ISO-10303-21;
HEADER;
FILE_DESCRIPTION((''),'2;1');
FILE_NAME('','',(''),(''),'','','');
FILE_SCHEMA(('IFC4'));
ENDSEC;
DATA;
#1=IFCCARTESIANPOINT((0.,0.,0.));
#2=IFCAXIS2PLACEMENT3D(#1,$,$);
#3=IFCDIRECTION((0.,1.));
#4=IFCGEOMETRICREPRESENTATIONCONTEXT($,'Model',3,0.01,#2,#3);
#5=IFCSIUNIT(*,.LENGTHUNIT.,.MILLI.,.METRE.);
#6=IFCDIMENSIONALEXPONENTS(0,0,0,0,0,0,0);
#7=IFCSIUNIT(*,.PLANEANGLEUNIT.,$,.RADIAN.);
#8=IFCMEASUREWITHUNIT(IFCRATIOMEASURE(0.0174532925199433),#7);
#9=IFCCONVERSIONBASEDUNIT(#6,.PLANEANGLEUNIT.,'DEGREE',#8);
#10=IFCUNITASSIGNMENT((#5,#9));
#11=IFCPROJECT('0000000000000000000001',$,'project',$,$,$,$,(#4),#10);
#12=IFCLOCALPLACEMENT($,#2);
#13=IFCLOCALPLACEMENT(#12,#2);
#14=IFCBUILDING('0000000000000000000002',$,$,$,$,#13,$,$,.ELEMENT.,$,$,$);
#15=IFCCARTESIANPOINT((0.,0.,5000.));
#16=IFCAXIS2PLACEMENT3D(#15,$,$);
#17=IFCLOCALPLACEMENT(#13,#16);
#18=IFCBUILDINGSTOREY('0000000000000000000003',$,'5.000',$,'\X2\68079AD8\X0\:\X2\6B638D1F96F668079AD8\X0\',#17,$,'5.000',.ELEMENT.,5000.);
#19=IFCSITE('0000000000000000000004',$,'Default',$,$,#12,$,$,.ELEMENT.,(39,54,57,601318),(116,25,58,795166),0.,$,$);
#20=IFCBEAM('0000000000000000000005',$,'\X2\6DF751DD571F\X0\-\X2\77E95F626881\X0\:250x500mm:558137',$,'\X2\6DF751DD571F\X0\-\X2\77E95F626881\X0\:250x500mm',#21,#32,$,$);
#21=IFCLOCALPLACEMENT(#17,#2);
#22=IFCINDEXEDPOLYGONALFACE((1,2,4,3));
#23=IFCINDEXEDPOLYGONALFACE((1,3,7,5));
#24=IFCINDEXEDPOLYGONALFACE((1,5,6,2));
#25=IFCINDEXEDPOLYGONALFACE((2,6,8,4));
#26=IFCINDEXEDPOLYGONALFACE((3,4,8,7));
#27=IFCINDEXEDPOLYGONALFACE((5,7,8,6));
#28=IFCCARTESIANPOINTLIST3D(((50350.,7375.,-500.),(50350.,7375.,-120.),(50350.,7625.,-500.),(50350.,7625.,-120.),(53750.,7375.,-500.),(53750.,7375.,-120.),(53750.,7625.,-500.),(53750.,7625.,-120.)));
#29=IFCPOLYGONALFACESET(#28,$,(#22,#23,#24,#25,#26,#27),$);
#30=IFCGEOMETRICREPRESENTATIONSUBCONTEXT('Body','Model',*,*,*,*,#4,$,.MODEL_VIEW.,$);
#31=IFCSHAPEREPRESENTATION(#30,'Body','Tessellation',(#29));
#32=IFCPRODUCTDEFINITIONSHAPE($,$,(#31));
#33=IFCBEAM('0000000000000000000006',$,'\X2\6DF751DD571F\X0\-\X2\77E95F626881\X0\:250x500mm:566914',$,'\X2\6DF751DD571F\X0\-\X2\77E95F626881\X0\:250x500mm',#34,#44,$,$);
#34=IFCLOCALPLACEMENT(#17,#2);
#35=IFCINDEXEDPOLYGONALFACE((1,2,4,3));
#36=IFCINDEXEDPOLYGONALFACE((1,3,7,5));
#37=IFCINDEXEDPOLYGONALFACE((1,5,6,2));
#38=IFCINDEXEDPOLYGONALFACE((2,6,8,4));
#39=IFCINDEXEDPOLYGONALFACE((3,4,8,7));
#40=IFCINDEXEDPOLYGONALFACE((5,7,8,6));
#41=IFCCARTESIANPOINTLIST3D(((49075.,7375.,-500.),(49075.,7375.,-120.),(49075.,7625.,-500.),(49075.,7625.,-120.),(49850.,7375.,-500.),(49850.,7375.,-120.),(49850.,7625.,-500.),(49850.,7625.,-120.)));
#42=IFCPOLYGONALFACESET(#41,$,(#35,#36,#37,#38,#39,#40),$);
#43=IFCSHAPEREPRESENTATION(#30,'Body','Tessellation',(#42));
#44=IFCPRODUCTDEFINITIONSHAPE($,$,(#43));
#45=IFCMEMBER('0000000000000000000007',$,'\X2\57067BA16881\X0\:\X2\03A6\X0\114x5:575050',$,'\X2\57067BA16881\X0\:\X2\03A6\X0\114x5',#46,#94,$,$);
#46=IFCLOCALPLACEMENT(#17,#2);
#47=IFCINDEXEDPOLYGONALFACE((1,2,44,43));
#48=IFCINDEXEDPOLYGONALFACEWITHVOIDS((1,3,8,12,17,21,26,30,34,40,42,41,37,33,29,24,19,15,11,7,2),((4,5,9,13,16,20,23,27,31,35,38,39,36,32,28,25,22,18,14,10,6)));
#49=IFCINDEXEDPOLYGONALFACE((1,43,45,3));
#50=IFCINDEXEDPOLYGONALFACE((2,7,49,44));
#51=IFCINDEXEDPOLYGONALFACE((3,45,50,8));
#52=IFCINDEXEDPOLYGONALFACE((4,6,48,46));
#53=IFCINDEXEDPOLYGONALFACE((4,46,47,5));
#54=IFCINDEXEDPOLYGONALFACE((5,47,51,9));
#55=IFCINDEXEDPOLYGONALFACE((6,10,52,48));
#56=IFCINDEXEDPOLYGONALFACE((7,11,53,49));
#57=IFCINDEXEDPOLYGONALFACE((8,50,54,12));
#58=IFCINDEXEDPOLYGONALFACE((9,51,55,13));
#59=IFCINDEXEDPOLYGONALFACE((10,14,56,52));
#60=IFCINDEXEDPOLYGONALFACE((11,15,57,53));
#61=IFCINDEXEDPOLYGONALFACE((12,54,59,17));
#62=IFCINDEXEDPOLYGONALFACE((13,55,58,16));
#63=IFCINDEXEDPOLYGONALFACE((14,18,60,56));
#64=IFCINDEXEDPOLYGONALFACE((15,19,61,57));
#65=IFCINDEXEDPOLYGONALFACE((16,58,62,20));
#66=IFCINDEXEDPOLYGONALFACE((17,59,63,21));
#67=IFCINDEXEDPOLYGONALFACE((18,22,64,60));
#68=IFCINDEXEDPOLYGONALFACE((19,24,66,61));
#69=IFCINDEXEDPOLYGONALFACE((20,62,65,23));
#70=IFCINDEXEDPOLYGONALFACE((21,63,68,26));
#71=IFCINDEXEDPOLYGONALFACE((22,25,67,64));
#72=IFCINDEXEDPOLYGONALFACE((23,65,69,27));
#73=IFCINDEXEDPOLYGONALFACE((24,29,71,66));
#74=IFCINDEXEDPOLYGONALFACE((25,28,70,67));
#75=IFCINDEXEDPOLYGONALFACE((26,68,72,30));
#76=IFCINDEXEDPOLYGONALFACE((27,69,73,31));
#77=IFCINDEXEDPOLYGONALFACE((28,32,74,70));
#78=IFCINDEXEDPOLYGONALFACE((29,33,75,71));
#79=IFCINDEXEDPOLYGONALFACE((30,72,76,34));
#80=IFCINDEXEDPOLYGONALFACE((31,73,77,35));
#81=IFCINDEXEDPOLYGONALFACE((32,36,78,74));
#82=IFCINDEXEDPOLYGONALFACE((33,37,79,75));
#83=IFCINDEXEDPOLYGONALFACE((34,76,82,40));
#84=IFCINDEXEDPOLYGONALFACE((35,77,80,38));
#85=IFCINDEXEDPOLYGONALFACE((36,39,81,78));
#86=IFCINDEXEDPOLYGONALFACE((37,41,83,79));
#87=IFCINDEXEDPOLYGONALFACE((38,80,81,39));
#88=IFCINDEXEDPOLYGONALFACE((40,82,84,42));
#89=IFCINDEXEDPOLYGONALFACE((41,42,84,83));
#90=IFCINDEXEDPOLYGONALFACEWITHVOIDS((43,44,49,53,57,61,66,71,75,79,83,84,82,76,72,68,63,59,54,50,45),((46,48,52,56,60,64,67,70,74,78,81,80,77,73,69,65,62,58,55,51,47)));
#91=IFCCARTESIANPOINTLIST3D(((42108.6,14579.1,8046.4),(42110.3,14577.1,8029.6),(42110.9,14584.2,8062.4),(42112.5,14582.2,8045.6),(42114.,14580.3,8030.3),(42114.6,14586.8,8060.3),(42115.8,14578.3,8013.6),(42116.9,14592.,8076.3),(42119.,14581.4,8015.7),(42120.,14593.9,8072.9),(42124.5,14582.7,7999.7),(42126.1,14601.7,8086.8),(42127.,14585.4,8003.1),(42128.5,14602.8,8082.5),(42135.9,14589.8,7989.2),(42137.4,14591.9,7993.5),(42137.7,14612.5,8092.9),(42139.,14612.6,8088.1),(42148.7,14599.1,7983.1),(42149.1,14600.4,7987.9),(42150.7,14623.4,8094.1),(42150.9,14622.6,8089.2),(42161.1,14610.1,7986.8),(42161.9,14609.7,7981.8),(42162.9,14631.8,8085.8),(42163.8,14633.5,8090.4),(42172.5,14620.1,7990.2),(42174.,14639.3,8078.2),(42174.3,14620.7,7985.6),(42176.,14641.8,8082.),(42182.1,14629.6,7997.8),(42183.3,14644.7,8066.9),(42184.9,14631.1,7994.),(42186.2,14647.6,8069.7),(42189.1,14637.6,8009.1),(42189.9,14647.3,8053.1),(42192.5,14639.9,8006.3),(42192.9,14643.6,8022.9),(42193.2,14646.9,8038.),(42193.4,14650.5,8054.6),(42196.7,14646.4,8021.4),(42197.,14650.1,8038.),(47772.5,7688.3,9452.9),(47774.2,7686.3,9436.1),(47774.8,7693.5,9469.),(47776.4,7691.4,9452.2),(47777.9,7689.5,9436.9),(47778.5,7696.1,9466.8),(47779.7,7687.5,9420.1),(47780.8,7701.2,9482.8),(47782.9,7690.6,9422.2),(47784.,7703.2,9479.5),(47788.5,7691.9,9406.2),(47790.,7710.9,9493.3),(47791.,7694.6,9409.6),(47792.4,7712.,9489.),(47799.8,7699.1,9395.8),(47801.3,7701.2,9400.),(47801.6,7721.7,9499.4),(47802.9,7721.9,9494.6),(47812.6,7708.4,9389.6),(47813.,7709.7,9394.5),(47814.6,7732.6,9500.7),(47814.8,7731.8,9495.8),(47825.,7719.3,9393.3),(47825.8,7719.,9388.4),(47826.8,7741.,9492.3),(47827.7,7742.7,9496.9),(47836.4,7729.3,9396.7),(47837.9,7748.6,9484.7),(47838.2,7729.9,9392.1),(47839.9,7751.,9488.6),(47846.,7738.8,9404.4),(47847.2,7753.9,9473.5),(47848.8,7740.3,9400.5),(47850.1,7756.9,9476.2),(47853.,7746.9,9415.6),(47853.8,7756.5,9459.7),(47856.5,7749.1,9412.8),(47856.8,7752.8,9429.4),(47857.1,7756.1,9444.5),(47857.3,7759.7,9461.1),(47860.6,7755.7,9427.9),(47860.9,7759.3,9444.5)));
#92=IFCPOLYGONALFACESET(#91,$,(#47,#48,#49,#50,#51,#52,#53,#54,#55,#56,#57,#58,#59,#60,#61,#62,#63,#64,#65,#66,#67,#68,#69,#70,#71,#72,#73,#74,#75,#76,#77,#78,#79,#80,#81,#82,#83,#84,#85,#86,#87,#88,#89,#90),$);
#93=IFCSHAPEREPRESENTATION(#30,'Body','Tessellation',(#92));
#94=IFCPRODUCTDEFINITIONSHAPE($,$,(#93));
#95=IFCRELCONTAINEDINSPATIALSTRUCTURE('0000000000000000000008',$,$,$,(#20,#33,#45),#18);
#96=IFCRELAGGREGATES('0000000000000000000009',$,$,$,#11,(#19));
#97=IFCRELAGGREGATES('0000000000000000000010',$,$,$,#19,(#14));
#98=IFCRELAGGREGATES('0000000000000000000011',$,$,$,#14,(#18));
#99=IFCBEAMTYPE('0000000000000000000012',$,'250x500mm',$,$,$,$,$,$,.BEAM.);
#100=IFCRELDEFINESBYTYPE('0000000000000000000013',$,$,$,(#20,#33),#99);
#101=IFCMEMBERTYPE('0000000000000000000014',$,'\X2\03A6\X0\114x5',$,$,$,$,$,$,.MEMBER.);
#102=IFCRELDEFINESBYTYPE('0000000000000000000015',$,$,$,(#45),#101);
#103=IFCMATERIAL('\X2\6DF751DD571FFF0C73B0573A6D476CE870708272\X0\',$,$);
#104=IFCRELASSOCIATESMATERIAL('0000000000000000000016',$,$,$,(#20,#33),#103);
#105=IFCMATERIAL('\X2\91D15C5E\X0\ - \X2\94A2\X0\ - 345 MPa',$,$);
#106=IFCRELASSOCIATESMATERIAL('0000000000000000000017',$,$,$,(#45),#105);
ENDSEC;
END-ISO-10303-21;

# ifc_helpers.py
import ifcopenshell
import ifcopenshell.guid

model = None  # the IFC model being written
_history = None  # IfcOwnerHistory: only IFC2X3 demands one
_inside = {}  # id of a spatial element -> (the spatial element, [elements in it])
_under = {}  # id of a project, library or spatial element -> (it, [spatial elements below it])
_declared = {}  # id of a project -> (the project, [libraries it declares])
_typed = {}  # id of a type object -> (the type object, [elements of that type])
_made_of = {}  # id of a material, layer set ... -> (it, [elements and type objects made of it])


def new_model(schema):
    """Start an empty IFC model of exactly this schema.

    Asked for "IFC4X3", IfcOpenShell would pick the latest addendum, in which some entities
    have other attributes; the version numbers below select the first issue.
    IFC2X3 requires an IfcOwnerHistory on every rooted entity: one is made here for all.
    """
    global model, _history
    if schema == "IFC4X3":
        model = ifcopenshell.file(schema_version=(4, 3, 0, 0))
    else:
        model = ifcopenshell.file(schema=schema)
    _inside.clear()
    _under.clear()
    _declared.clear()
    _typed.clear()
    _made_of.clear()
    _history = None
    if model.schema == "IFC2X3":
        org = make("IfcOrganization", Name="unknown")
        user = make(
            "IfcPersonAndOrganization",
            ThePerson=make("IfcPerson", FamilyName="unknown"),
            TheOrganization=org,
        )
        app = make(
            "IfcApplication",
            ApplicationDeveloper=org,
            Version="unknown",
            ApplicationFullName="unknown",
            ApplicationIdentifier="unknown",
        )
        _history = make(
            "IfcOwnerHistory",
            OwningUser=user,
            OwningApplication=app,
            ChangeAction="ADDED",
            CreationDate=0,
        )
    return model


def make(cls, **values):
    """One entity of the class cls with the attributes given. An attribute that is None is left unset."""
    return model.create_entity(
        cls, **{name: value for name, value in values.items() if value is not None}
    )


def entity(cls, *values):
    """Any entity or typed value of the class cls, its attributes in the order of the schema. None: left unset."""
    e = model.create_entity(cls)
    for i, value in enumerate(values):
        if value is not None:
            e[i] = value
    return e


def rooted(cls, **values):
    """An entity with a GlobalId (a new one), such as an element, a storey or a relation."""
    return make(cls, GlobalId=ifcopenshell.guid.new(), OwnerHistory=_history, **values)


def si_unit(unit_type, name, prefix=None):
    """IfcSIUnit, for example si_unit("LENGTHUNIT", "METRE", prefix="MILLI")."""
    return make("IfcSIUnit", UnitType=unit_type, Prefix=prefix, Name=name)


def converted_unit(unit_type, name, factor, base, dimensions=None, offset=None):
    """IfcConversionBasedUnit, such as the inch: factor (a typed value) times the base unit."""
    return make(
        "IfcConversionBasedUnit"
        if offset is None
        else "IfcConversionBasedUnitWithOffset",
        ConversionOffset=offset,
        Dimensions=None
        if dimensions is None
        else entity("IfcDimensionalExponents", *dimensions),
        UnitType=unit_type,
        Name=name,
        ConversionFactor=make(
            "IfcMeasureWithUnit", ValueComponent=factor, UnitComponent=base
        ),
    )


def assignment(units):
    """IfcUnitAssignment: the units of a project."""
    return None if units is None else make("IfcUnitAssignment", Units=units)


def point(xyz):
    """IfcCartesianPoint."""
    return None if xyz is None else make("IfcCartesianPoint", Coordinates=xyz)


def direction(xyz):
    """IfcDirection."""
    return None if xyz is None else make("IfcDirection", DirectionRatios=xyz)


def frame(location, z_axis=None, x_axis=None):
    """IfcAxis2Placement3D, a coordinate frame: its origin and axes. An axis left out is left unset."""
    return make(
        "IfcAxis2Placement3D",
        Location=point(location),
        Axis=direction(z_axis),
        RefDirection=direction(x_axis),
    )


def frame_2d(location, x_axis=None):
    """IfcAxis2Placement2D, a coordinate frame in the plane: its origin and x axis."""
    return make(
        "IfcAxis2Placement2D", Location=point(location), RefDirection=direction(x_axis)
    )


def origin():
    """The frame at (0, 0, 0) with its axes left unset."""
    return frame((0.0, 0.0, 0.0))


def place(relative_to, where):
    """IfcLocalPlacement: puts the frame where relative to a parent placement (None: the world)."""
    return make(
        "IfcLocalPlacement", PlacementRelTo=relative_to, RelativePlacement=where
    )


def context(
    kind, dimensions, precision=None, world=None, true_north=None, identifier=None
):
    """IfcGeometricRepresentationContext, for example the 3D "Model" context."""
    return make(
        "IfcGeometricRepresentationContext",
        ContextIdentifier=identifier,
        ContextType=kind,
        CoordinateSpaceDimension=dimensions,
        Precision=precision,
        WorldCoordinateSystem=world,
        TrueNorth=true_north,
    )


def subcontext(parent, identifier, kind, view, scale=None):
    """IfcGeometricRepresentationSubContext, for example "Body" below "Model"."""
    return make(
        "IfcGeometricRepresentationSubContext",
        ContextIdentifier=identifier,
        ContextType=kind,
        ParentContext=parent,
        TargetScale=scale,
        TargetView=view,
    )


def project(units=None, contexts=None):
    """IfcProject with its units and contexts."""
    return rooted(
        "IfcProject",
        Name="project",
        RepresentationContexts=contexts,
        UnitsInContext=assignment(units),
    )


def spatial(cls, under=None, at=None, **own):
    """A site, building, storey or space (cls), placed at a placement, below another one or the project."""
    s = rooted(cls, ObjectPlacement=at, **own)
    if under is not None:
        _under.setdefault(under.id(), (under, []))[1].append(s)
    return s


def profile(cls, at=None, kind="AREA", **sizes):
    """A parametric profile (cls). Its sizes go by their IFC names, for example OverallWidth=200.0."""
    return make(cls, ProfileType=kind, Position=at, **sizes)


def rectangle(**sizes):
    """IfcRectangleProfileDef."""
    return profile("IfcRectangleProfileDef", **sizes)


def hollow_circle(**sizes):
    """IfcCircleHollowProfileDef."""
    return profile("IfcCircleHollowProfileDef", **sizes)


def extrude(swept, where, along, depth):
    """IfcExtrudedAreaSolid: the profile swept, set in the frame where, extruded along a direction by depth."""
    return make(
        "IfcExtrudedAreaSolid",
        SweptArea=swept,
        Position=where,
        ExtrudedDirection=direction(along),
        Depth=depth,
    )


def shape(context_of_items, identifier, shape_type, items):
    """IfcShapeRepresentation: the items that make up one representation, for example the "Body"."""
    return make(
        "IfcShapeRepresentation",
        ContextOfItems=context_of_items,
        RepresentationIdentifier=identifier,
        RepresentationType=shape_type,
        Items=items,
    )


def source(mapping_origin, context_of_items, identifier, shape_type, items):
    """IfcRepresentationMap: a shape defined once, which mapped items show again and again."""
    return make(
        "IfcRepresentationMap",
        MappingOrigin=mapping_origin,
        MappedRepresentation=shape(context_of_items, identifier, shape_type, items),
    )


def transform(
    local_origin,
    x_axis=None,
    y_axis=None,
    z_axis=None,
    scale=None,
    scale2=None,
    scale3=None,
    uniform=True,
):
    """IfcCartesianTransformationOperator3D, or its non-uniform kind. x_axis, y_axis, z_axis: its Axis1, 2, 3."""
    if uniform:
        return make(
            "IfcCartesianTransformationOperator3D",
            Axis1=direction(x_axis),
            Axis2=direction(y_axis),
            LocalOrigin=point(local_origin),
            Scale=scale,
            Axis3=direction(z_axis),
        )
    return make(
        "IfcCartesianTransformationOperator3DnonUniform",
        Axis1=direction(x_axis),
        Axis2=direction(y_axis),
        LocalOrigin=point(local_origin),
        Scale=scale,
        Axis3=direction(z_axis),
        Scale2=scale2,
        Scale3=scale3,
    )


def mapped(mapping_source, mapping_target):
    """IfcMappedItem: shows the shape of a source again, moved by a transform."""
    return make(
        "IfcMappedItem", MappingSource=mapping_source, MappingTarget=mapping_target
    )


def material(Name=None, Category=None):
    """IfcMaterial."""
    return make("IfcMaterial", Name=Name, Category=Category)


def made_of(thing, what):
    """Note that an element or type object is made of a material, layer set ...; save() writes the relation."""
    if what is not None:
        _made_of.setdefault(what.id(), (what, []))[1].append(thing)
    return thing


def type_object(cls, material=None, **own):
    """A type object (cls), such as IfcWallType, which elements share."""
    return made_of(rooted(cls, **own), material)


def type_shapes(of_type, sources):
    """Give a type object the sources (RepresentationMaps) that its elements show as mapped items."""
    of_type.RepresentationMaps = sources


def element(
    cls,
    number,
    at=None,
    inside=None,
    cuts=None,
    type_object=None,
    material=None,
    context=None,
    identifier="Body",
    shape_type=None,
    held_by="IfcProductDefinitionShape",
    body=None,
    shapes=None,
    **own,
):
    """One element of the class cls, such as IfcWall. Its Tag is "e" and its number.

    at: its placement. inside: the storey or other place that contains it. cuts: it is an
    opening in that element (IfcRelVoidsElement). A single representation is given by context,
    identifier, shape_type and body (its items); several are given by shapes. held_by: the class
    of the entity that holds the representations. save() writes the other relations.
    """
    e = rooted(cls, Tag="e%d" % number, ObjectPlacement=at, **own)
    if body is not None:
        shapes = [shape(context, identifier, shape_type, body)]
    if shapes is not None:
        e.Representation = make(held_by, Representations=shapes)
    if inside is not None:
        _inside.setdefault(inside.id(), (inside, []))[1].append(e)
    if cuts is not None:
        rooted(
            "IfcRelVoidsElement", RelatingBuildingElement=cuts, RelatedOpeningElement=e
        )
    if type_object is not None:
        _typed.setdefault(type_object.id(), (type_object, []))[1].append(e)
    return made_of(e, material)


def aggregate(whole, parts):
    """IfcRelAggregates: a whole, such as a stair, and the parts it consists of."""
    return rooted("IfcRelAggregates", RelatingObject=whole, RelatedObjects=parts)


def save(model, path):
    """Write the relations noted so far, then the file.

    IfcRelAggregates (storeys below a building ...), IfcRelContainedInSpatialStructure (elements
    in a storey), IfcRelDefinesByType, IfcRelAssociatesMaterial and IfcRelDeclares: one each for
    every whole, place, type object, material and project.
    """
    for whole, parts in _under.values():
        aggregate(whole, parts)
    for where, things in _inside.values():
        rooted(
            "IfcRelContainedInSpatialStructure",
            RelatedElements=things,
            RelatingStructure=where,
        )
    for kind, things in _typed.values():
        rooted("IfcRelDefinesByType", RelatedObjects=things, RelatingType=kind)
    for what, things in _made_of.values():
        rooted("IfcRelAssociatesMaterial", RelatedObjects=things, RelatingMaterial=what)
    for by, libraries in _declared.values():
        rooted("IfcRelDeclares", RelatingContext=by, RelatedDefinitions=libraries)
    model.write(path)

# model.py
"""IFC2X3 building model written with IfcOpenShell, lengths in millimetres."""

from ifc_helpers import new_model, entity, si_unit, converted_unit, direction, frame, frame_2d, origin, place, context, subcontext, project, spatial, rectangle, hollow_circle, extrude, source, transform, mapped, material, type_object, type_shapes, element, save


model = new_model("IFC2X3")

# Units and contexts
model_context = context("Model", 3, precision=0.01, world=origin(), true_north=direction((0.0, 1.0)))
body_context = subcontext(model_context, "Body", "Model", "MODEL_VIEW")
ifc_project = project(units=[si_unit("LENGTHUNIT", "METRE", prefix="MILLI"), converted_unit("PLANEANGLEUNIT", "DEGREE", entity("IfcRatioMeasure", 0.0174532925199433), si_unit("PLANEANGLEUNIT", "RADIAN"), dimensions=[0, 0, 0, 0, 0, 0, 0])], contexts=[model_context])

# Site, building, storey
site_placement = place(None, origin())
site = spatial("IfcSite", under=ifc_project, at=site_placement, Name="Default", CompositionType="ELEMENT", RefLatitude=(39, 54, 57, 601318), RefLongitude=(116, 25, 58, 795166), RefElevation=0.0)
building_placement = place(site_placement, origin())
building = spatial("IfcBuilding", under=site, at=building_placement, CompositionType="ELEMENT")
storey_placement = place(building_placement, frame((0.0, 0.0, 5000.0)))
storey = spatial("IfcBuildingStorey", under=building, at=storey_placement, Name="5.000", ObjectType="标高:正负零标高", LongName="5.000", CompositionType="ELEMENT", Elevation=5000.0)

# Beams
ifc_material_1 = material(Name="混凝土，现场浇注灰色")
beam_type_1 = type_object("IfcBeamType", Name="250x500mm", PredefinedType="BEAM")
beam_1_placement = place(storey_placement, frame((49850.0, 7500.0, 0.0)))
element("IfcBeam", 1, at=beam_1_placement, inside=storey, type_object=beam_type_1, material=ifc_material_1, Name="混凝土-矩形梁:250x500mm:558137", ObjectType="混凝土-矩形梁:250x500mm", context=body_context, shape_type="SweptSolid", body=[
    extrude(rectangle(XDim=380.0, YDim=250.0, at=frame_2d((0.0, 0.0), x_axis=(1.0, 0.0))), frame((500.0, 0.0, -310.0), z_axis=(1.0, 0.0, 0.0), x_axis=(0.0, 0.0, -1.0)), (0.0, 0.0, 1.0), 3400.0),
])
beam_2_placement = place(storey_placement, frame((48950.0, 7500.0, 0.0)))
element("IfcBeam", 2, at=beam_2_placement, inside=storey, type_object=beam_type_1, material=ifc_material_1, Name="混凝土-矩形梁:250x500mm:566914", ObjectType="混凝土-矩形梁:250x500mm", context=body_context, shape_type="SweptSolid", body=[
    extrude(rectangle(XDim=380.0, YDim=250.0, at=frame_2d((0.0, 0.0), x_axis=(1.0, 0.0))), frame((125.0, 0.0, -310.0), z_axis=(1.0, 0.0, 0.0), x_axis=(0.0, 0.0, -1.0)), (0.0, 0.0, 1.0), 775.0),
])

# Member
ifc_material_2 = material(Name="金属 - 钢 - 345 MPa")
member_type_1 = type_object("IfcMemberType", Name="Φ114x5", PredefinedType="MEMBER")
shared_shape_1 = source(origin(), body_context, "Body", "SweptSolid", [
    extrude(hollow_circle(Radius=57.0, WallThickness=5.0, at=frame_2d((0.0, 0.0), x_axis=(1.0, 0.0))), frame((-4539.0, 0.0, 0.0), z_axis=(1.0, 0.0, 0.0), x_axis=(0.0, 1.0, 0.0)), (0.0, 0.0, 1.0), 9030.0),
])
type_shapes(member_type_1, [shared_shape_1])
for number, where, z_axis, x_axis, name in (
    (3, (45000.0, 11150.2, 8745.0), (-0.098907, 0.120331, 0.987794), (0.627233, -0.763097, 0.155763), "圆管梁:Φ114x5:575050"),
):
    element("IfcMember", number, at=place(storey_placement, frame(where, z_axis=z_axis, x_axis=x_axis)), inside=storey, type_object=member_type_1, material=ifc_material_2, Name=name, ObjectType="圆管梁:Φ114x5", context=body_context, shape_type="MappedRepresentation", body=[
        mapped(shared_shape_1, transform((0.0, 0.0, 0.0), scale=1.0)),
    ])

save(model, "model.ifc")
